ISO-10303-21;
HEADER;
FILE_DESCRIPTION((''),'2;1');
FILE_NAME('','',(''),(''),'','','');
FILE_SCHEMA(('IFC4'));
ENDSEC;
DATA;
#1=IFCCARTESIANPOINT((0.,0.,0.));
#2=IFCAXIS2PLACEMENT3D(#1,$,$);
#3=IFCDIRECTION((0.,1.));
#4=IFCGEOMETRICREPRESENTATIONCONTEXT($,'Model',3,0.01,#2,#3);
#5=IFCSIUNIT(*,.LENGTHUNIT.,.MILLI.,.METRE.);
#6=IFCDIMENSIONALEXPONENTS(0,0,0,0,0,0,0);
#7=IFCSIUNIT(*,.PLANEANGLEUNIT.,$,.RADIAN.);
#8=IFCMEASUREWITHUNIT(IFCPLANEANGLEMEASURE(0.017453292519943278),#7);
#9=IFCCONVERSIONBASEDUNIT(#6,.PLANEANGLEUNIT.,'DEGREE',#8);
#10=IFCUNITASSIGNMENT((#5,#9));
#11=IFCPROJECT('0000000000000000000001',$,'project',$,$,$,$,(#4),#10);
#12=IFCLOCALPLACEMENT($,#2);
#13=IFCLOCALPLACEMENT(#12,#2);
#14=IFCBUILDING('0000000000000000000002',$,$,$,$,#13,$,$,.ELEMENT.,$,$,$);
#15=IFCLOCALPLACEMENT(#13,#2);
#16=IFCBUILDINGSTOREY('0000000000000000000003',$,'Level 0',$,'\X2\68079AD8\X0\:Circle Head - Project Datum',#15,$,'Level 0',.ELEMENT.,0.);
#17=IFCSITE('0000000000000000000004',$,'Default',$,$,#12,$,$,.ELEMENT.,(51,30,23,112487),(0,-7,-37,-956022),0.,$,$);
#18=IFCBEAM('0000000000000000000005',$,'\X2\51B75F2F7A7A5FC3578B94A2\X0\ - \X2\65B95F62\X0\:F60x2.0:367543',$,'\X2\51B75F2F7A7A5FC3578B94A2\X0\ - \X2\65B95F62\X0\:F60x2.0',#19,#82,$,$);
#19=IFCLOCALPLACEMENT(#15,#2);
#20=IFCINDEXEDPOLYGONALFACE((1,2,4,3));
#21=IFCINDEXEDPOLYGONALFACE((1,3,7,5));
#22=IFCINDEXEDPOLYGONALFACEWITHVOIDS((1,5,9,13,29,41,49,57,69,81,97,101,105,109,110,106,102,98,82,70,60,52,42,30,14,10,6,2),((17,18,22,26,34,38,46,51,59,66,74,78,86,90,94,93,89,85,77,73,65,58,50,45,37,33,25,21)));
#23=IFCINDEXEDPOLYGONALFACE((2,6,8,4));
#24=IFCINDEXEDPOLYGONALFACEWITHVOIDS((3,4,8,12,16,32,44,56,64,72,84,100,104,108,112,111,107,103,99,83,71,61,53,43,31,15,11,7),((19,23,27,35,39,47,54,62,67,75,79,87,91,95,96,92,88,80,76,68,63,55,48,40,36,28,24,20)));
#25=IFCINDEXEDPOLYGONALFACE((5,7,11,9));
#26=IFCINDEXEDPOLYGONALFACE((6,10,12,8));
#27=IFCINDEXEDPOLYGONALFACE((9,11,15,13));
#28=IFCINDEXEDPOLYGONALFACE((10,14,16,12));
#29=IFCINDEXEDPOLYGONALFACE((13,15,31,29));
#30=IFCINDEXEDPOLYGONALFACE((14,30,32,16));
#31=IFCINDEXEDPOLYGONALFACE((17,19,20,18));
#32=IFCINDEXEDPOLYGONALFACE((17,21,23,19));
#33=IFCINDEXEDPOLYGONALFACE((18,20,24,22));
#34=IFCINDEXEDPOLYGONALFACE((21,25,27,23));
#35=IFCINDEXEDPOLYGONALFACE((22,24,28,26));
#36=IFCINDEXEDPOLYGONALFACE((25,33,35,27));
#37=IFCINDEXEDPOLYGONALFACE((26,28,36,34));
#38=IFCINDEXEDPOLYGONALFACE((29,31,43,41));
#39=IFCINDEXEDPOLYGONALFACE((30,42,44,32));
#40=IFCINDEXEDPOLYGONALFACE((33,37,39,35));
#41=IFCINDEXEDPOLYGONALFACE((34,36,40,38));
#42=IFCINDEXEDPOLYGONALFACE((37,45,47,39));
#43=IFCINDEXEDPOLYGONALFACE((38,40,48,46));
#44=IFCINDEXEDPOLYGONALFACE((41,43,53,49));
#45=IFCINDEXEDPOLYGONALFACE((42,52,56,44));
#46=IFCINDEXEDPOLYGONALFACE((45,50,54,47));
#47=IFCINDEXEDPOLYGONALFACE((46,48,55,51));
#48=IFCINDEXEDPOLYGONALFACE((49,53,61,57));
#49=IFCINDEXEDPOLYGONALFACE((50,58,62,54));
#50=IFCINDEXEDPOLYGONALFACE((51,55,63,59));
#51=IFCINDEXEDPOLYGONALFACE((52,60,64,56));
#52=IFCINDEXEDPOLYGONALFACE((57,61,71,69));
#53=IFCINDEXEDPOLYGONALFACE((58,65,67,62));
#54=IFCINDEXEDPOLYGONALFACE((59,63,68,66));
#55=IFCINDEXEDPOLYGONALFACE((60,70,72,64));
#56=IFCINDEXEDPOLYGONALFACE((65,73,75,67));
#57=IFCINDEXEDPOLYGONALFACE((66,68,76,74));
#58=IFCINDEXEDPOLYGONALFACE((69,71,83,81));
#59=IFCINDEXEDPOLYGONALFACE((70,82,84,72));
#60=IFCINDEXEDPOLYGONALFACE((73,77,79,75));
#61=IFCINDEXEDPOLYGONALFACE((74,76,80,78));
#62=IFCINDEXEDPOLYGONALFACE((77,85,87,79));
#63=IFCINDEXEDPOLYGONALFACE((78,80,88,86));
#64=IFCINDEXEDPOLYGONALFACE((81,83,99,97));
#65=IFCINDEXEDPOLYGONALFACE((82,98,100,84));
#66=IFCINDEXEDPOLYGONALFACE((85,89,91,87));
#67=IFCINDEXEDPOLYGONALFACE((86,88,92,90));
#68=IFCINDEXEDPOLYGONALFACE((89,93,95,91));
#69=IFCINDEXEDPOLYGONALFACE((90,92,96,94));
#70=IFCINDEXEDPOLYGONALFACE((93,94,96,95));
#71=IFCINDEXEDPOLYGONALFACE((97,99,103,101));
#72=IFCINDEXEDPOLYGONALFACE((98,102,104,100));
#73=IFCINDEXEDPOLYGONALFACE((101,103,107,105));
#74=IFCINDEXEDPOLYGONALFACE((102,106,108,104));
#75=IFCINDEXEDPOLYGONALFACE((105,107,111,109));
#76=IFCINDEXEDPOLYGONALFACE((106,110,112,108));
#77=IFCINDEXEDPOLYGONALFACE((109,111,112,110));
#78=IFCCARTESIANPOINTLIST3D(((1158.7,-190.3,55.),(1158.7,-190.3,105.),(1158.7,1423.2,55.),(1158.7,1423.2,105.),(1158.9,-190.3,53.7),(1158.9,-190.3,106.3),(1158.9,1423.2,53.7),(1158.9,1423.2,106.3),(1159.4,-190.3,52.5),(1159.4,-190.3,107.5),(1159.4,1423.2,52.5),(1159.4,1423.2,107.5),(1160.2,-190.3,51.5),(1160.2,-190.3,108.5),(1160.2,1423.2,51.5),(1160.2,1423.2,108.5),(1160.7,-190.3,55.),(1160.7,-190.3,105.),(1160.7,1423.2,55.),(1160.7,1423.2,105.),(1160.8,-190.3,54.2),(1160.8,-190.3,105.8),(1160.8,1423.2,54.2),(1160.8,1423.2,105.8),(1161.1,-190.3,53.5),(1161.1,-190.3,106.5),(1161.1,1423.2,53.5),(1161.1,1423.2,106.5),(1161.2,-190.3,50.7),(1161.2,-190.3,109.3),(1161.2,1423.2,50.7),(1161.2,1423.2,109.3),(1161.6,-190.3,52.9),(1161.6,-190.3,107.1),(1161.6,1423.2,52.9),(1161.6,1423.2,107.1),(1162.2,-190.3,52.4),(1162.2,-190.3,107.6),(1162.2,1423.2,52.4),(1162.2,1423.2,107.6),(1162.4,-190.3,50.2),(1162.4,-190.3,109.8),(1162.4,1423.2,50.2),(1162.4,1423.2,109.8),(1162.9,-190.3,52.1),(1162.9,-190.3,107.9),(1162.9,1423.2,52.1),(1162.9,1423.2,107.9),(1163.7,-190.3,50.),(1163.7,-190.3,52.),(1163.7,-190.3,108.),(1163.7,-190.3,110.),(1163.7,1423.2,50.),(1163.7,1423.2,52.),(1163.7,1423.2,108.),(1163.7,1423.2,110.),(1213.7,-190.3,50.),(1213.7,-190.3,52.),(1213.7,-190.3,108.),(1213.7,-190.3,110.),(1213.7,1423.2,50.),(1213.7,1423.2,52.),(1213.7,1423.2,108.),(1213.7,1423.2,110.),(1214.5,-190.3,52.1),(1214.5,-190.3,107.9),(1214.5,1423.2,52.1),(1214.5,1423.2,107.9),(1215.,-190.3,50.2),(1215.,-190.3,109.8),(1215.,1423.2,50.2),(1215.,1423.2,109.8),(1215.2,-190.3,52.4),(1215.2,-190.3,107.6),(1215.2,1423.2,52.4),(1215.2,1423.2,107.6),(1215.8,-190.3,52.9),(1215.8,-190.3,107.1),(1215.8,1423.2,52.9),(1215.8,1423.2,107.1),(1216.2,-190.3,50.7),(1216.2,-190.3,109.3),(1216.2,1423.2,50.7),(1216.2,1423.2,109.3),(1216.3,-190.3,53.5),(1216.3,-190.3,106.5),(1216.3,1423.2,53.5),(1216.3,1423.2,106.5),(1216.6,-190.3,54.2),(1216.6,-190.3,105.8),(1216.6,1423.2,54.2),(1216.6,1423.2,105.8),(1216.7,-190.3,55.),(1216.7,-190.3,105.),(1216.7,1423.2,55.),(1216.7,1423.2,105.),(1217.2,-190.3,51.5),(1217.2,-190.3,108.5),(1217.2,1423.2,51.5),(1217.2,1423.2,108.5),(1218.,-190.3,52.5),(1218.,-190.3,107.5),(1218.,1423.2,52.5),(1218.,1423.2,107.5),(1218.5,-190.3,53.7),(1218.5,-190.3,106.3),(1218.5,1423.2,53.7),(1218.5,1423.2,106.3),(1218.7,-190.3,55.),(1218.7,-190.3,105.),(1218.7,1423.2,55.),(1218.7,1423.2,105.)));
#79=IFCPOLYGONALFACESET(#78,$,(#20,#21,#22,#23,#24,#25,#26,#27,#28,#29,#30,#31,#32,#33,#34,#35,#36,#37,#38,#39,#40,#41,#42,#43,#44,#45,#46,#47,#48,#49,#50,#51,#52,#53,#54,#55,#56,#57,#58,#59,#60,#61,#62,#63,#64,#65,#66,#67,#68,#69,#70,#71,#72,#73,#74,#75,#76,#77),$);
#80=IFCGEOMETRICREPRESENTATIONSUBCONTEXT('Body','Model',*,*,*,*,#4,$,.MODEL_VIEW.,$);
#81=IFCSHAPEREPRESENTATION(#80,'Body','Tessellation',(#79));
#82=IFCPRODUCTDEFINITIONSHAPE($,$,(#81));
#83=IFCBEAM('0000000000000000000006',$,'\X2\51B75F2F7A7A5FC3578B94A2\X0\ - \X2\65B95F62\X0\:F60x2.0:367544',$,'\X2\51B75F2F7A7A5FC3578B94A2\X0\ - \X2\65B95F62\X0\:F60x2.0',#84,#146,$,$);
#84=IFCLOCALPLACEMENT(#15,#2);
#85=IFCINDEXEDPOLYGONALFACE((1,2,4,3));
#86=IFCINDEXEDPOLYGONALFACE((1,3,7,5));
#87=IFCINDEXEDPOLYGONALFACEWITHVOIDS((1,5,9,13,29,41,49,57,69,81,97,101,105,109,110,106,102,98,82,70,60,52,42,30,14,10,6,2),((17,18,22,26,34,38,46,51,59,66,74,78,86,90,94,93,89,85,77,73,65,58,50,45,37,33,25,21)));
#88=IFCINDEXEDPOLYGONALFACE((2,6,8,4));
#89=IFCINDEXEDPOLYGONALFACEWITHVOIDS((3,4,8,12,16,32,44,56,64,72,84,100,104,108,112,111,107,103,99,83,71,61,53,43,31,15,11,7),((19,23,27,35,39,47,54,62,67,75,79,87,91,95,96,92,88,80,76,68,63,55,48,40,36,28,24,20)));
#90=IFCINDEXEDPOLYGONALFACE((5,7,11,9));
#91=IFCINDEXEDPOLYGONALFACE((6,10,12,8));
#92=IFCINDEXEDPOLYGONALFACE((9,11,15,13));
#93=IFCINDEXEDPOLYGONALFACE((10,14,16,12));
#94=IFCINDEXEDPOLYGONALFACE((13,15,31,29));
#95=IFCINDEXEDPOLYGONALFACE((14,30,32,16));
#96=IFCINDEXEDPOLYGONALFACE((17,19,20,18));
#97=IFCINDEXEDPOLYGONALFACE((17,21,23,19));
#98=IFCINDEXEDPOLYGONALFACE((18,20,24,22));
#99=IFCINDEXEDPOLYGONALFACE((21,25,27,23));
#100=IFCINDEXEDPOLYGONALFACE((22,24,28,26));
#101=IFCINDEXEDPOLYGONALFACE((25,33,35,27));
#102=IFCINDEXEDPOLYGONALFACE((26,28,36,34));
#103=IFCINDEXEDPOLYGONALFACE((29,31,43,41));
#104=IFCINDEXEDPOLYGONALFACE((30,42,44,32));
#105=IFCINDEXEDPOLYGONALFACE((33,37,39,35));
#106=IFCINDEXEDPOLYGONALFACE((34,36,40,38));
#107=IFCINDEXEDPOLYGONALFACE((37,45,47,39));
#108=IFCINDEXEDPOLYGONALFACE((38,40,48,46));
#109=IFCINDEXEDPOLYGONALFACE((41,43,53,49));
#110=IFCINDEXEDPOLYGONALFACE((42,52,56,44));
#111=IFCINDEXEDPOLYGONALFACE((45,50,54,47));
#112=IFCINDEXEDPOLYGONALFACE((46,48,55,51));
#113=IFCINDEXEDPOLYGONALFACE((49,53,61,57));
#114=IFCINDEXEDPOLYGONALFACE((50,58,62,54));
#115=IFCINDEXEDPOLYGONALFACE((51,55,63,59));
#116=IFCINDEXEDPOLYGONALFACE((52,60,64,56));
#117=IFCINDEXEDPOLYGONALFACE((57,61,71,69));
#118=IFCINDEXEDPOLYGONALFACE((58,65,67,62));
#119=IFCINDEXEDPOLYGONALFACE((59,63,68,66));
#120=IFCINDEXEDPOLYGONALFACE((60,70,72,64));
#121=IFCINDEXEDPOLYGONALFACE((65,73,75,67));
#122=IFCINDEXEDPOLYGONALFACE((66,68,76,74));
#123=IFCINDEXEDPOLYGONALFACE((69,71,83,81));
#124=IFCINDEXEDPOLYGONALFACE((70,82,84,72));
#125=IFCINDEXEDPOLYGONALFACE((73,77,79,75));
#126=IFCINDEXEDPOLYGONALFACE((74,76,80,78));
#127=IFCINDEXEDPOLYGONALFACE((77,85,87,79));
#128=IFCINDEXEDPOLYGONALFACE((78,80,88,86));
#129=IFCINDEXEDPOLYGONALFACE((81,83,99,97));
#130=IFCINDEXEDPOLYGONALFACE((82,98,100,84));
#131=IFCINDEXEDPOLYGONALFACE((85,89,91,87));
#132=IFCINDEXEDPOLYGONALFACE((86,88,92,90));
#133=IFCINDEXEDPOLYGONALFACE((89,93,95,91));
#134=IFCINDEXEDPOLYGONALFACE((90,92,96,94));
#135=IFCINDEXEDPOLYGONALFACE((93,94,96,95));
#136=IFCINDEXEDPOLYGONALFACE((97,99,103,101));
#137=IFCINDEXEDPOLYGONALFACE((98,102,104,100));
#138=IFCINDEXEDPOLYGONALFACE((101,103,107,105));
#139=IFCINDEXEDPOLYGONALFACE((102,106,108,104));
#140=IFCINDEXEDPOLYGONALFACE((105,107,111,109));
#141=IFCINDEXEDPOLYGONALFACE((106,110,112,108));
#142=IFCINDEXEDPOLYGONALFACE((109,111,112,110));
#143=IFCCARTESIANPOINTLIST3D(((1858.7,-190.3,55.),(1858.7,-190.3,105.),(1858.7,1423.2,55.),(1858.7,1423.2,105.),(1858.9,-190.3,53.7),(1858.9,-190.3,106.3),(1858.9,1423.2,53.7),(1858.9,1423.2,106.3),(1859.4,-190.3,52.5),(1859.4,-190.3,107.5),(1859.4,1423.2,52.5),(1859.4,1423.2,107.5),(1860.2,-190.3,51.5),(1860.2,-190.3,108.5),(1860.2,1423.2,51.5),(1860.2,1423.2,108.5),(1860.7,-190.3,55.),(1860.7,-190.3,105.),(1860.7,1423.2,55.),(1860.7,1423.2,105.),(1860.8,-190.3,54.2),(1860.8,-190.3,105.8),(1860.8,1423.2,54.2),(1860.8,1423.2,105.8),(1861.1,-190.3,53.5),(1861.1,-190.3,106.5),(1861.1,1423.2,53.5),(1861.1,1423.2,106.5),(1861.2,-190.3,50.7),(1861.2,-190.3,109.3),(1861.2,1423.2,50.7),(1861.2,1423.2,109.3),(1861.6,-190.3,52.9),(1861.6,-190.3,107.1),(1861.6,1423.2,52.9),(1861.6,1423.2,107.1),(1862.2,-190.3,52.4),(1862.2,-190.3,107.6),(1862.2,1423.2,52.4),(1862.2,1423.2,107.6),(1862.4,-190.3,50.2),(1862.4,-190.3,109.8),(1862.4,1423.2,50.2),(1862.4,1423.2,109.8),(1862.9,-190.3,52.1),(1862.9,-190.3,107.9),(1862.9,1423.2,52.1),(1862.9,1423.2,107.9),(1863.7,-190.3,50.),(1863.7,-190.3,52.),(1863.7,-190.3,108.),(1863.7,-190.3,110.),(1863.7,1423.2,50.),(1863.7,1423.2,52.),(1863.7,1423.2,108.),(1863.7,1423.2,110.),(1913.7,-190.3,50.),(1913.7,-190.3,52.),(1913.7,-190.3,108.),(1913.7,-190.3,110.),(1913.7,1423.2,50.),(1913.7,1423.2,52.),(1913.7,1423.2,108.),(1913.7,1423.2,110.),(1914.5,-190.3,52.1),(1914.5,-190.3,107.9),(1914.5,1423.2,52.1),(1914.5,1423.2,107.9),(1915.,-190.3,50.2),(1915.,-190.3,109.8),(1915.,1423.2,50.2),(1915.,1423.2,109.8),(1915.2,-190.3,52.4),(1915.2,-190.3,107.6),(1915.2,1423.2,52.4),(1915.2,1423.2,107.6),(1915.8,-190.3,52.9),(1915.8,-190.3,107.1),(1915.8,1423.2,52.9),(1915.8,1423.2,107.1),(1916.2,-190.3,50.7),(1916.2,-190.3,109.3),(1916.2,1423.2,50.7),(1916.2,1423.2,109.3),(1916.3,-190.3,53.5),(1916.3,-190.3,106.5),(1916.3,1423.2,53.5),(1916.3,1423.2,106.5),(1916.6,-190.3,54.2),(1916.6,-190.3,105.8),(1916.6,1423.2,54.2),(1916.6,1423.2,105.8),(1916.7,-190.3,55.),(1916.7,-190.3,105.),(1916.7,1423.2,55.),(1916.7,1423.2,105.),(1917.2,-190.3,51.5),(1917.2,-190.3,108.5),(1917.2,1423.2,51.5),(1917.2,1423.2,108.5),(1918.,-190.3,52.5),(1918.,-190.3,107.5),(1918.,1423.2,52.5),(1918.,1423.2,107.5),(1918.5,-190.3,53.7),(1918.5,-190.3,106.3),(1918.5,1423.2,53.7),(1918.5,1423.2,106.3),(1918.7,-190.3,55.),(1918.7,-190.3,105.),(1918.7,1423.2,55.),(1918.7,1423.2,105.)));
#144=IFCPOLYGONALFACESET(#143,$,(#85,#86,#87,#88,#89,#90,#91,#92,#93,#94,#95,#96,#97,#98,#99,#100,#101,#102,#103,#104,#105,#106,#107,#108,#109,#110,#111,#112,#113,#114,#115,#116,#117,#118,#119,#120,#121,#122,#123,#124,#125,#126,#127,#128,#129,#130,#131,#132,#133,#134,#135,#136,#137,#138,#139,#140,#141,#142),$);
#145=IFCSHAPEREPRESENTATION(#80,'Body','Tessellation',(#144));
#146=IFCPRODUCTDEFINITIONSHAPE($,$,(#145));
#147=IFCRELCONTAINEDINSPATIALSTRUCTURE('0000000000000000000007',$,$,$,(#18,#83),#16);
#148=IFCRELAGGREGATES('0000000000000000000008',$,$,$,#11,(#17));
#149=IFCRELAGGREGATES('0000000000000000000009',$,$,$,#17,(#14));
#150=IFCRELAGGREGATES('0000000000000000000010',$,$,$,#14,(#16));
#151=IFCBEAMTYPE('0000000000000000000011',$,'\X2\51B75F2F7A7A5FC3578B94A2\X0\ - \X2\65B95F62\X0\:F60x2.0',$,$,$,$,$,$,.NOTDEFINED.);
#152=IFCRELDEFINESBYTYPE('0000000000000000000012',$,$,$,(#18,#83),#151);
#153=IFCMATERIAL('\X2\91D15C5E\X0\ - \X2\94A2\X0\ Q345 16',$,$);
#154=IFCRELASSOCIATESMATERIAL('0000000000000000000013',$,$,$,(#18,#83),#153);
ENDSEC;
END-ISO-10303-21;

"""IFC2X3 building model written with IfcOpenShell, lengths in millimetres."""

from ifc_helpers import new_model, entity, si_unit, converted_unit, direction, frame, frame_2d, origin, place, context, subcontext, project, spatial, polyline, circle_curve, parameter, trimmed, segment, composite_curve, outline, extrude, material, type_object, element, save


model = new_model("IFC2X3")

# Units and contexts
model_context = context("Model", 3, precision=0.01, world=origin(), true_north=direction((0.0, 1.0)))
body_context = subcontext(model_context, "Body", "Model", "MODEL_VIEW")
ifc_project = project(units=[si_unit("LENGTHUNIT", "METRE", prefix="MILLI"), converted_unit("PLANEANGLEUNIT", "DEGREE", entity("IfcPlaneAngleMeasure", 0.017453292519943278), si_unit("PLANEANGLEUNIT", "RADIAN"), dimensions=[0, 0, 0, 0, 0, 0, 0])], contexts=[model_context])

# Site, building, storey
site_placement = place(None, origin())
site = spatial("IfcSite", under=ifc_project, at=site_placement, Name="Default", CompositionType="ELEMENT", RefLatitude=(51, 30, 23, 112487), RefLongitude=(0, -7, -37, -956022), RefElevation=0.0)
building_placement = place(site_placement, origin())
building = spatial("IfcBuilding", under=site, at=building_placement, CompositionType="ELEMENT")
storey_placement = place(building_placement, origin())
storey = spatial("IfcBuildingStorey", under=building, at=storey_placement, Name="Level 0", ObjectType="标高:Circle Head - Project Datum", LongName="Level 0", CompositionType="ELEMENT", Elevation=0.0)

# Beams
ifc_material_1 = material(Name="金属 - 钢 Q345 16")
beam_type_1 = type_object("IfcBeamType", Name="冷弯空心型钢 - 方形:F60x2.0", PredefinedType="NOTDEFINED")
beam_1_placement = place(storey_placement, frame((1188.7, 1388.1, 110.0), z_axis=(0.0, 0.0, 1.0), x_axis=(0.0, -1.0, 0.0)))
element("IfcBeam", 1, at=beam_1_placement, inside=storey, type_object=beam_type_1, material=ifc_material_1, Name="冷弯空心型钢 - 方形:F60x2.0:367543", ObjectType="冷弯空心型钢 - 方形:F60x2.0", context=body_context, shape_type="SweptSolid", body=[
    extrude(outline(composite_curve([segment(trimmed(circle_curve(frame_2d((-25.0, 25.0), x_axis=(1.0, 0.0)), 5.0), [parameter(90.0)], [parameter(180.0)], True, "PARAMETER"), True, "CONTINUOUS"), segment(polyline([(-30.0, 25.0), (-30.0, -25.0)]), True, "CONTINUOUS"), segment(trimmed(circle_curve(frame_2d((-25.0, -25.0), x_axis=(1.0, 0.0)), 5.0), [parameter(180.0)], [parameter(270.0)], True, "PARAMETER"), True, "CONTINUOUS"), segment(polyline([(-25.0, -30.0), (25.0, -30.0)]), True, "CONTINUOUS"), segment(trimmed(circle_curve(frame_2d((25.0, -25.0), x_axis=(1.0, 0.0)), 5.0), [parameter(270.0)], [parameter(0.0)], True, "PARAMETER"), True, "CONTINUOUS"), segment(polyline([(30.0, -25.0), (30.0, 25.0)]), True, "CONTINUOUS"), segment(trimmed(circle_curve(frame_2d((25.0, 25.0), x_axis=(1.0, 0.0)), 5.0), [parameter(0.0)], [parameter(90.0)], True, "PARAMETER"), True, "CONTINUOUS"), segment(polyline([(25.0, 30.0), (-25.0, 30.0)]), True, "CONTINUOUS")], self_intersect=False), holes=[composite_curve([segment(polyline([(-25.0, 28.0), (25.0, 28.0)]), True, "CONTINUOUS"), segment(trimmed(circle_curve(frame_2d((25.0, 25.0), x_axis=(1.0, 0.0)), 3.0), [parameter(0.0)], [parameter(90.0)], True, "PARAMETER"), False, "CONTINUOUS"), segment(polyline([(28.0, 25.0), (28.0, -25.0)]), True, "CONTINUOUS"), segment(trimmed(circle_curve(frame_2d((25.0, -25.0), x_axis=(1.0, 0.0)), 3.0), [parameter(270.0)], [parameter(360.0)], True, "PARAMETER"), False, "CONTINUOUS"), segment(polyline([(25.0, -28.0), (-25.0, -28.0)]), True, "CONTINUOUS"), segment(trimmed(circle_curve(frame_2d((-25.0, -25.0), x_axis=(1.0, 0.0)), 3.0), [parameter(180.0)], [parameter(270.0)], True, "PARAMETER"), False, "CONTINUOUS"), segment(polyline([(-28.0, -25.0), (-28.0, 25.0)]), True, "CONTINUOUS"), segment(trimmed(circle_curve(frame_2d((-25.0, 25.0), x_axis=(1.0, 0.0)), 3.0), [parameter(90.0)], [parameter(180.0)], True, "PARAMETER"), False, "CONTINUOUS")], self_intersect=False)]), frame((-35.1, 0.0, -30.0), z_axis=(1.0, 0.0, 0.0), x_axis=(0.0, 1.0, 0.0)), (0.0, 0.0, 1.0), 1613.5),
])
beam_2_placement = place(storey_placement, frame((1888.7, 1388.1, 110.0), z_axis=(0.0, 0.0, 1.0), x_axis=(0.0, -1.0, 0.0)))
element("IfcBeam", 2, at=beam_2_placement, inside=storey, type_object=beam_type_1, material=ifc_material_1, Name="冷弯空心型钢 - 方形:F60x2.0:367544", ObjectType="冷弯空心型钢 - 方形:F60x2.0", context=body_context, shape_type="SweptSolid", body=[
    extrude(outline(composite_curve([segment(trimmed(circle_curve(frame_2d((-25.0, 25.0), x_axis=(1.0, 0.0)), 5.0), [parameter(90.0)], [parameter(180.0)], True, "PARAMETER"), True, "CONTINUOUS"), segment(polyline([(-30.0, 25.0), (-30.0, -25.0)]), True, "CONTINUOUS"), segment(trimmed(circle_curve(frame_2d((-25.0, -25.0), x_axis=(1.0, 0.0)), 5.0), [parameter(180.0)], [parameter(270.0)], True, "PARAMETER"), True, "CONTINUOUS"), segment(polyline([(-25.0, -30.0), (25.0, -30.0)]), True, "CONTINUOUS"), segment(trimmed(circle_curve(frame_2d((25.0, -25.0), x_axis=(1.0, 0.0)), 5.0), [parameter(270.0)], [parameter(0.0)], True, "PARAMETER"), True, "CONTINUOUS"), segment(polyline([(30.0, -25.0), (30.0, 25.0)]), True, "CONTINUOUS"), segment(trimmed(circle_curve(frame_2d((25.0, 25.0), x_axis=(1.0, 0.0)), 5.0), [parameter(0.0)], [parameter(90.0)], True, "PARAMETER"), True, "CONTINUOUS"), segment(polyline([(25.0, 30.0), (-25.0, 30.0)]), True, "CONTINUOUS")], self_intersect=False), holes=[composite_curve([segment(polyline([(-25.0, 28.0), (25.0, 28.0)]), True, "CONTINUOUS"), segment(trimmed(circle_curve(frame_2d((25.0, 25.0), x_axis=(1.0, 0.0)), 3.0), [parameter(0.0)], [parameter(90.0)], True, "PARAMETER"), False, "CONTINUOUS"), segment(polyline([(28.0, 25.0), (28.0, -25.0)]), True, "CONTINUOUS"), segment(trimmed(circle_curve(frame_2d((25.0, -25.0), x_axis=(1.0, 0.0)), 3.0), [parameter(270.0)], [parameter(360.0)], True, "PARAMETER"), False, "CONTINUOUS"), segment(polyline([(25.0, -28.0), (-25.0, -28.0)]), True, "CONTINUOUS"), segment(trimmed(circle_curve(frame_2d((-25.0, -25.0), x_axis=(1.0, 0.0)), 3.0), [parameter(180.0)], [parameter(270.0)], True, "PARAMETER"), False, "CONTINUOUS"), segment(polyline([(-28.0, -25.0), (-28.0, 25.0)]), True, "CONTINUOUS"), segment(trimmed(circle_curve(frame_2d((-25.0, 25.0), x_axis=(1.0, 0.0)), 3.0), [parameter(90.0)], [parameter(180.0)], True, "PARAMETER"), False, "CONTINUOUS")], self_intersect=False)]), frame((-35.1, 0.0, -30.0), z_axis=(1.0, 0.0, 0.0), x_axis=(0.0, 1.0, 0.0)), (0.0, 0.0, 1.0), 1613.5),
])

save(model, "model.ifc")
